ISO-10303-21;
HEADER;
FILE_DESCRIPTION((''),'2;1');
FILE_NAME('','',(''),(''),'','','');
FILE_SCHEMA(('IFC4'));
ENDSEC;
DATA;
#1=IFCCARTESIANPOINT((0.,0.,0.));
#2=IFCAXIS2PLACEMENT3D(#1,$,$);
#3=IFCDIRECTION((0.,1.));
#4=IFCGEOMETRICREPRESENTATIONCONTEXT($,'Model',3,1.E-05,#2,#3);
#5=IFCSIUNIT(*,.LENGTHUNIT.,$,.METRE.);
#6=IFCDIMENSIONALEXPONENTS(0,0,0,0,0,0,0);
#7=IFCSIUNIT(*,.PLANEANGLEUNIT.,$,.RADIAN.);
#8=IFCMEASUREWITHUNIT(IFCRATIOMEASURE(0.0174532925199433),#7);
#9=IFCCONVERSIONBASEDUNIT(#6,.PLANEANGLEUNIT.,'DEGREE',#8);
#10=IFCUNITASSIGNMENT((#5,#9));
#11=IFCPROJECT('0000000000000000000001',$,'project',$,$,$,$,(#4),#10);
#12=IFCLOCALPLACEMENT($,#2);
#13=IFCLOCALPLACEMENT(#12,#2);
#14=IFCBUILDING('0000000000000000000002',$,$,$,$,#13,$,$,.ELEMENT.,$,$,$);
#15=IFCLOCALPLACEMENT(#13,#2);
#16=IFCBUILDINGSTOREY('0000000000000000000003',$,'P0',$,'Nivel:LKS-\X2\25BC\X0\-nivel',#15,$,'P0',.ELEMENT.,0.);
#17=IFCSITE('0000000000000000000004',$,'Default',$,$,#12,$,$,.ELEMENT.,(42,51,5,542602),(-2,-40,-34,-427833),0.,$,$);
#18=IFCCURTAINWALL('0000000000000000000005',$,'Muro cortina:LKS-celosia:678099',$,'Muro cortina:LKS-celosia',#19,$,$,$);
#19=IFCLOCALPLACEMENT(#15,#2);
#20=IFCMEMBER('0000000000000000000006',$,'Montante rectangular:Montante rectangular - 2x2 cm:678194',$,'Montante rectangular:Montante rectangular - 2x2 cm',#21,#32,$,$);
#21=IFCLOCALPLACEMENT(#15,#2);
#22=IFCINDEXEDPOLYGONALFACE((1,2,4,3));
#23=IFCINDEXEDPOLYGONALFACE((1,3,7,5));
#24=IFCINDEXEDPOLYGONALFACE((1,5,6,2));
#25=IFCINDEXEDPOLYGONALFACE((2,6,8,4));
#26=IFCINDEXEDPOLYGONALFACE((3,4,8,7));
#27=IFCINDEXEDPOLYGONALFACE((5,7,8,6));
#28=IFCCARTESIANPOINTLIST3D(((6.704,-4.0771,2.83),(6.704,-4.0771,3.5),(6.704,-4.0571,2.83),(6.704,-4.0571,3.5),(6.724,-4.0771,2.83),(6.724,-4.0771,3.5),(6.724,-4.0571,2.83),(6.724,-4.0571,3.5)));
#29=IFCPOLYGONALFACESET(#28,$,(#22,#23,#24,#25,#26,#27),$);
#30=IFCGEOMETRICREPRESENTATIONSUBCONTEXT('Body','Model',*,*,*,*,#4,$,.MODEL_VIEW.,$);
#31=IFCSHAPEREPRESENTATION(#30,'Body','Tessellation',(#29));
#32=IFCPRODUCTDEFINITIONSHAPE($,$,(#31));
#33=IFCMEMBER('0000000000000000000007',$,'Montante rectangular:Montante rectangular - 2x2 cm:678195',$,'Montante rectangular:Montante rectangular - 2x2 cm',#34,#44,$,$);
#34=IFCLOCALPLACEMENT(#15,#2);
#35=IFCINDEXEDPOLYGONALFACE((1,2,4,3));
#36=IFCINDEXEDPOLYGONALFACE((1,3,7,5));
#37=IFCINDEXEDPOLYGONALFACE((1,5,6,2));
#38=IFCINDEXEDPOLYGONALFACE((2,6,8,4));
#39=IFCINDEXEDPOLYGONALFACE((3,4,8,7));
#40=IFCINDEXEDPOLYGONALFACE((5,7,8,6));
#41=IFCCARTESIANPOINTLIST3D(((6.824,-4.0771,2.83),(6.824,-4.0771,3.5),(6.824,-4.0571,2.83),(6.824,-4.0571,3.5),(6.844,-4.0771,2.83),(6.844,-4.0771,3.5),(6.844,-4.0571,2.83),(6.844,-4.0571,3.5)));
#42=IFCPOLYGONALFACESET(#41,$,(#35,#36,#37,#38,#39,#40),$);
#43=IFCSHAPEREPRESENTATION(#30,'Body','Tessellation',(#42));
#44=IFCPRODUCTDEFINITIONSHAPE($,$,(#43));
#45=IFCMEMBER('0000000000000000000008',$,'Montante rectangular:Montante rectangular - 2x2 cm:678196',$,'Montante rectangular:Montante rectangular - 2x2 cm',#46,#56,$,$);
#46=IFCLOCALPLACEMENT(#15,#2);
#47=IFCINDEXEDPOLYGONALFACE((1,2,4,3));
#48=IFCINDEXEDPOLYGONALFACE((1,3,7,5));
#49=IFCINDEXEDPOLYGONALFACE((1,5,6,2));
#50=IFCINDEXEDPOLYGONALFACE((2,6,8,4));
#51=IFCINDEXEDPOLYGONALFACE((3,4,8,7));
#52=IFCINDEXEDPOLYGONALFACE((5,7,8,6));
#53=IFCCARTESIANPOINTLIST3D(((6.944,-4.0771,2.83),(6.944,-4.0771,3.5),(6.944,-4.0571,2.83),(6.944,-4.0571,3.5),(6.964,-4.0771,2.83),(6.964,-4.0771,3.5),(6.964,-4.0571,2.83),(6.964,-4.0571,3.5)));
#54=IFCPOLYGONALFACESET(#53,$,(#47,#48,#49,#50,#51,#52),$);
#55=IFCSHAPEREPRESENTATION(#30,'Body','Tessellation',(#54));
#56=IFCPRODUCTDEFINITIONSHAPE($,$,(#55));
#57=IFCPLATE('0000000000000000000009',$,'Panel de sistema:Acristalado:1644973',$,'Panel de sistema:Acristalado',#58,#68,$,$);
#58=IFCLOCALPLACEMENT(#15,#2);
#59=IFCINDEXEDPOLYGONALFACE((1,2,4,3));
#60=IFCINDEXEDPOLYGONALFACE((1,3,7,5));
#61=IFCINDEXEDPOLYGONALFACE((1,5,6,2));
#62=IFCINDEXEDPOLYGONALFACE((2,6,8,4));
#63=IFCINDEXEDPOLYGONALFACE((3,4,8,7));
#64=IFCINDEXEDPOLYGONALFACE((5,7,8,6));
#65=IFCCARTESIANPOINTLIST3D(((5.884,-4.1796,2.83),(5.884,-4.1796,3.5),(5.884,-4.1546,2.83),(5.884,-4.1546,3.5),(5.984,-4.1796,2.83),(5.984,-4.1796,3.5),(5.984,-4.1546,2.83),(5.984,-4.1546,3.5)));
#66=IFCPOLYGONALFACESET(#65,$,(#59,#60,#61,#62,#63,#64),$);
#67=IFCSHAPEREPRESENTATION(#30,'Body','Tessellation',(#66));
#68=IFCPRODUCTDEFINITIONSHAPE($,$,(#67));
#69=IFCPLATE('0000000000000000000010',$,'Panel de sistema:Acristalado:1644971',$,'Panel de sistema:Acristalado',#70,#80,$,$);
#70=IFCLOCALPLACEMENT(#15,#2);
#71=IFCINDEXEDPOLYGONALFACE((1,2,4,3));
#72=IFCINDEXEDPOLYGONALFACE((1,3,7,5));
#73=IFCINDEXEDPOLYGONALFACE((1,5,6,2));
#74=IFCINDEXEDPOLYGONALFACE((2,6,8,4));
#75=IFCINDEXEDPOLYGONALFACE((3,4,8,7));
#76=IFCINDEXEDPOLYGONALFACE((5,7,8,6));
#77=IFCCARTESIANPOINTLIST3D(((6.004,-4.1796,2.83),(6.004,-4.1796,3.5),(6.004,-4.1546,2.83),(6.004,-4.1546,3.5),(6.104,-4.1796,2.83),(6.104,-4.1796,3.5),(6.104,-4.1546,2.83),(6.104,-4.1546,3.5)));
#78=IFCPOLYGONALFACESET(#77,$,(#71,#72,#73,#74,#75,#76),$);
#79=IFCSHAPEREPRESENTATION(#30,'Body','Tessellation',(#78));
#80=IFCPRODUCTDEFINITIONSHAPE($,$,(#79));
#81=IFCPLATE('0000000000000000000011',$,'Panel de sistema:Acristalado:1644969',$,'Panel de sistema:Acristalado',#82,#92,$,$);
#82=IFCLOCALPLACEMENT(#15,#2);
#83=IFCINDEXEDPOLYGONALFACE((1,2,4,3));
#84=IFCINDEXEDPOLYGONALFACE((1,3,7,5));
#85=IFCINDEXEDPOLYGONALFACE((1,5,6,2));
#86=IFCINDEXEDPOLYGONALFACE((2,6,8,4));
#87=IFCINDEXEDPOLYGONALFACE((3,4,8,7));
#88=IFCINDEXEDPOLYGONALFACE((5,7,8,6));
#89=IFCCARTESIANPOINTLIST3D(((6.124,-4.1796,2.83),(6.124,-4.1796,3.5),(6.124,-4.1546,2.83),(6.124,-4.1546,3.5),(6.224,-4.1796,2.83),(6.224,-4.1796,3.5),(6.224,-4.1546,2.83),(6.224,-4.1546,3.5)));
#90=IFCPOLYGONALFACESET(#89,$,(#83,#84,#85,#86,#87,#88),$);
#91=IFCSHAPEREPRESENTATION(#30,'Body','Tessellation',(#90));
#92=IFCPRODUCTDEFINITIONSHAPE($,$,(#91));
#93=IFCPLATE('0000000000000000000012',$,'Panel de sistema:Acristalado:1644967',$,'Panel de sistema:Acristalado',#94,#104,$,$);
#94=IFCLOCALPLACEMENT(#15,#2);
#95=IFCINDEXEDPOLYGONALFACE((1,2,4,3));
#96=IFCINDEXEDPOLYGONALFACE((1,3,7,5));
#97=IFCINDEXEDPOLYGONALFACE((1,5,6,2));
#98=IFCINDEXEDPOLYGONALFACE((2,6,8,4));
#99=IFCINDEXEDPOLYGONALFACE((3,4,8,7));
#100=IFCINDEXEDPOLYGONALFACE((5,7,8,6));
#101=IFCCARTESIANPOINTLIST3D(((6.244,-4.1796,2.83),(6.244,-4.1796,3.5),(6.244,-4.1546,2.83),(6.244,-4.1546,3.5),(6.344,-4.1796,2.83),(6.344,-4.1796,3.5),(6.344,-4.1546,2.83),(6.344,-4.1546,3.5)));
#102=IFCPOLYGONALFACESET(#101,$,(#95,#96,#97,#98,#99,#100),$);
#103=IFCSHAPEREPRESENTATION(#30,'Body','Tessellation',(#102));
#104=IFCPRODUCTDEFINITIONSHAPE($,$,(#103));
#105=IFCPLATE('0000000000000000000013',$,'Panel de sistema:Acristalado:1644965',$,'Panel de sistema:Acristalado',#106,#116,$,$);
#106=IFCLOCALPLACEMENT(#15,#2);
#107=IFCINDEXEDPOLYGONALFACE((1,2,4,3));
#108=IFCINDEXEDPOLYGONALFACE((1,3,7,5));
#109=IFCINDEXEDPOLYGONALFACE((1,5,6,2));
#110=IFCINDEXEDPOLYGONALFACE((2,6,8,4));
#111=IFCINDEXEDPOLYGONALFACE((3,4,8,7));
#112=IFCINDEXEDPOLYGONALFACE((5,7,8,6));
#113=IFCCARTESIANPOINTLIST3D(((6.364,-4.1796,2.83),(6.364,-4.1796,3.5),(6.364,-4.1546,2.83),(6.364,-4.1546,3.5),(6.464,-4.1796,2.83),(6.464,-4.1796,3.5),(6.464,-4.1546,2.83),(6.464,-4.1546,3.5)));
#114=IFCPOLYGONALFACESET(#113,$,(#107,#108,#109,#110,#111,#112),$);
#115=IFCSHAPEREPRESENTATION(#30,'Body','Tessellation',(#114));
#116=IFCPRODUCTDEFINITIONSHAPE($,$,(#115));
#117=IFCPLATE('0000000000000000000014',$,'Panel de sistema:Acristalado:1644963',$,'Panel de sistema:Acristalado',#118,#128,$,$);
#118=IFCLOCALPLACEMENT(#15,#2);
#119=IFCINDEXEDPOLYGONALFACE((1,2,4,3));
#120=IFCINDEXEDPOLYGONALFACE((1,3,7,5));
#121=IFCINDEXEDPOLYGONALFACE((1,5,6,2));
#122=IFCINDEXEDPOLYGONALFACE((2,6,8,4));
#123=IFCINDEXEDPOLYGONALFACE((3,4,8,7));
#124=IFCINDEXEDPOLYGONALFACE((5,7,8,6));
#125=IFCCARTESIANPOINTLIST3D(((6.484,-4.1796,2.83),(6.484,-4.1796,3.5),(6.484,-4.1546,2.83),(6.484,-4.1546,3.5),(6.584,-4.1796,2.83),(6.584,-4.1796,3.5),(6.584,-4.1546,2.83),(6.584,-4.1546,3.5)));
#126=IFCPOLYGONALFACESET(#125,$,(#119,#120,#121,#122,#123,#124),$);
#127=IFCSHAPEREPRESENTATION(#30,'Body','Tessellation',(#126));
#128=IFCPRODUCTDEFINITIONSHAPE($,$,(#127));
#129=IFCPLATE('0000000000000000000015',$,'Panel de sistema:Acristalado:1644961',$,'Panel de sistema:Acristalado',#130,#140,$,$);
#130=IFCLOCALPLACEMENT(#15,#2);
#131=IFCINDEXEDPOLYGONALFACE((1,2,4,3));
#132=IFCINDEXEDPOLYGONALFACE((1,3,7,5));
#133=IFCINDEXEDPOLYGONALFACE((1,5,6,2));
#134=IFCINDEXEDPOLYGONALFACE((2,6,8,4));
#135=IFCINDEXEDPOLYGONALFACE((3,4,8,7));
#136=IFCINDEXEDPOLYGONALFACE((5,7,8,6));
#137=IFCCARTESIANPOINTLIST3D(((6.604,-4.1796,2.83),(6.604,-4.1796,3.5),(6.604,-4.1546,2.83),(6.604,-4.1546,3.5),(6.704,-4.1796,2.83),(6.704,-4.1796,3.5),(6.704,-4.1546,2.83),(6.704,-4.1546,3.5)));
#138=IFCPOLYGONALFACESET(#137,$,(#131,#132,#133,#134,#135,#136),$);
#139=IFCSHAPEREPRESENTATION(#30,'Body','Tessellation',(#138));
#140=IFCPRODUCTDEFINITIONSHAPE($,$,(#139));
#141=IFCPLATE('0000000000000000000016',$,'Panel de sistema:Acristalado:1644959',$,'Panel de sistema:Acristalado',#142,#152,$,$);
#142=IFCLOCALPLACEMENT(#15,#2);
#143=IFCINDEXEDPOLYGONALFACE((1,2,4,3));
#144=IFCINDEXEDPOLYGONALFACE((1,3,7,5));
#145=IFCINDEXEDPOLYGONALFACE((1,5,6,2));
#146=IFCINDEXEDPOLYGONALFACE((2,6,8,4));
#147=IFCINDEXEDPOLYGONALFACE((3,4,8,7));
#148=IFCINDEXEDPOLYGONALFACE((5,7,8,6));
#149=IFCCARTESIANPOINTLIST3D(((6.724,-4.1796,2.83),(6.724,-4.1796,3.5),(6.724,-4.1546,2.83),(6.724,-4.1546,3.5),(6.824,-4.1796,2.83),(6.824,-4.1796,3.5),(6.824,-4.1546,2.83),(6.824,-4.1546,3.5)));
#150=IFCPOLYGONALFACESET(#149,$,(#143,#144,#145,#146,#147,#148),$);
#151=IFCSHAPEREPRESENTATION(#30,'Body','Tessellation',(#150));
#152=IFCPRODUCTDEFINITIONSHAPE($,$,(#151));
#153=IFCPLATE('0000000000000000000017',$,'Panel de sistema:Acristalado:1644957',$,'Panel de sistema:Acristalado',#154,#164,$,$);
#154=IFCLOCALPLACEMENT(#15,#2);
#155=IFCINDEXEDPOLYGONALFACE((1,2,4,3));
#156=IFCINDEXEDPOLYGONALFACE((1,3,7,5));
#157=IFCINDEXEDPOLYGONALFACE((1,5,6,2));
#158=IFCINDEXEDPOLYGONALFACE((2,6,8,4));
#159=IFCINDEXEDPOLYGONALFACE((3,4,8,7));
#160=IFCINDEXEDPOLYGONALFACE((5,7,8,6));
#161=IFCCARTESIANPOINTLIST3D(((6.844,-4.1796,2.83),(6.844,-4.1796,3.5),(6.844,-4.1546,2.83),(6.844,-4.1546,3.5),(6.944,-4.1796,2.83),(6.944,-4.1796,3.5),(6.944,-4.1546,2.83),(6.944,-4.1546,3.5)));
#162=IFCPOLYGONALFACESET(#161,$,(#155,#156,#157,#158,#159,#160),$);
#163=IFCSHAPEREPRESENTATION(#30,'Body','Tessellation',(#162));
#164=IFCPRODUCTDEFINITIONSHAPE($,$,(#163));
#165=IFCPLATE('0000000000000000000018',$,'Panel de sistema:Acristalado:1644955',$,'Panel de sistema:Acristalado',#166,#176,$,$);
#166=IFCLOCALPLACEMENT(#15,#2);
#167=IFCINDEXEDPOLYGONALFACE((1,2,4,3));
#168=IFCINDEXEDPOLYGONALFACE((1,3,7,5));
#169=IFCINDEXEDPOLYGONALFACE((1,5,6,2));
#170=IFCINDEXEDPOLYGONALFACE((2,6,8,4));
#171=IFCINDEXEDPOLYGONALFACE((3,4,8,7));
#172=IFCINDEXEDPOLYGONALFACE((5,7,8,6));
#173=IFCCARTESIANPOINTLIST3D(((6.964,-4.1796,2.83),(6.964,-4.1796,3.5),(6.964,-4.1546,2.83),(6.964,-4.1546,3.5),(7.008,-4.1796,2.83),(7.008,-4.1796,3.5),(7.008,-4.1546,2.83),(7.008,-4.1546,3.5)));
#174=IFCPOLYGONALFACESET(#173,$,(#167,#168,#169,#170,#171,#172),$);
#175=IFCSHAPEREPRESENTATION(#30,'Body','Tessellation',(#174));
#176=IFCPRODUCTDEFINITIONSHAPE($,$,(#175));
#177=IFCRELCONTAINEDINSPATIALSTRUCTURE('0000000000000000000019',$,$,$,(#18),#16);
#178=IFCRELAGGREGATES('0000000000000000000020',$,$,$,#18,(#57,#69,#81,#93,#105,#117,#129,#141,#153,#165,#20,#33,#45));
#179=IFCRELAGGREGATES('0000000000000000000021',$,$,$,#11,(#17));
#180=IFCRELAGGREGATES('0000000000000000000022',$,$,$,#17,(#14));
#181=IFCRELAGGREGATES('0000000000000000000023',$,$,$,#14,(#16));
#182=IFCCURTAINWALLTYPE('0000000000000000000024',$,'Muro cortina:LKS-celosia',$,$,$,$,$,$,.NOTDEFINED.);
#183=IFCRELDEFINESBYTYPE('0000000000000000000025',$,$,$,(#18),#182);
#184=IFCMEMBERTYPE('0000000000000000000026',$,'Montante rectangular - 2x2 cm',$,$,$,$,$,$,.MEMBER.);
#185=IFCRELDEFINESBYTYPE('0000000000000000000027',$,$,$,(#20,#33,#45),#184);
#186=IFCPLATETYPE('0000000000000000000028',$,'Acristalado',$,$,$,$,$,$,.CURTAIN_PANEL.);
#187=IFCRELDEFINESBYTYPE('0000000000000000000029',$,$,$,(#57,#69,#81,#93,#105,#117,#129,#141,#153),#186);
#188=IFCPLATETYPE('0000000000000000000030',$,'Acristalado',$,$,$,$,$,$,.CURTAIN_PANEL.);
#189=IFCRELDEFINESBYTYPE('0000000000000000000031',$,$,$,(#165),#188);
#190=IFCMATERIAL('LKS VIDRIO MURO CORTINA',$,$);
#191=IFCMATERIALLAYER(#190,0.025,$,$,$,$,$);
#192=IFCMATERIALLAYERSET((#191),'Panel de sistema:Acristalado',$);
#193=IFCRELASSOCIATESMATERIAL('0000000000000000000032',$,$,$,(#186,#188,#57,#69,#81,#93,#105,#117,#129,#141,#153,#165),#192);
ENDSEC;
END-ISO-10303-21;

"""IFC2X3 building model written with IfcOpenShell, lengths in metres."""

from ifc_helpers import new_model, entity, si_unit, converted_unit, direction, frame, origin, origin_2d_with_axis, place, context, subcontext, project, spatial, rectangle, extrude, source, transform, mapped, material, layer, layer_set, layer_usage, type_object, type_shapes, element, aggregate, save


model = new_model("IFC2X3")

# Units and contexts
model_context = context("Model", 3, precision=1e-05, world=origin(), true_north=direction((0.0, 1.0)))
body_context = subcontext(model_context, "Body", "Model", "MODEL_VIEW")
ifc_project = project(units=[si_unit("LENGTHUNIT", "METRE"), converted_unit("PLANEANGLEUNIT", "DEGREE", entity("IfcRatioMeasure", 0.0174532925199433), si_unit("PLANEANGLEUNIT", "RADIAN"), dimensions=[0, 0, 0, 0, 0, 0, 0])], contexts=[model_context])

# Site, building, storey
site_placement = place(None, origin())
site = spatial("IfcSite", under=ifc_project, at=site_placement, Name="Default", CompositionType="ELEMENT", RefLatitude=(42, 51, 5, 542602), RefLongitude=(-2, -40, -34, -427833), RefElevation=0.0)
building_placement = place(site_placement, origin())
building = spatial("IfcBuilding", under=site, at=building_placement, CompositionType="ELEMENT")
storey_placement = place(building_placement, origin())
storey = spatial("IfcBuildingStorey", under=building, at=storey_placement, Name="P0", ObjectType="Nivel:LKS-▼-nivel", LongName="P0", CompositionType="ELEMENT", Elevation=0.0)

# Curtain wall
curtain_wall_type = type_object("IfcCurtainWallType", Name="Muro cortina:LKS-celosia", PredefinedType="NOTDEFINED")
curtain_wall_1_placement = place(storey_placement, origin())
curtain_wall_1 = element("IfcCurtainWall", 1, at=curtain_wall_1_placement, inside=storey, type_object=curtain_wall_type, Name="Muro cortina:LKS-celosia:678099", ObjectType="Muro cortina:LKS-celosia")

# Shared definitions
member_type_1 = type_object("IfcMemberType", Name="Montante rectangular - 2x2 cm", PredefinedType="MEMBER")
shared_shape_1 = source(origin(), body_context, "Body", "SweptSolid", [
    extrude(rectangle(XDim=0.02, YDim=0.02, at=origin_2d_with_axis()), frame((0.0, -0.1, -0.67), z_axis=(0.0, 0.0, 1.0), x_axis=(0.0, -1.0, 0.0)), (0.0, 0.0, 1.0), 0.67),
])
type_shapes(member_type_1, [shared_shape_1])

# Members
member_1_placement = place(storey_placement, frame((6.714, -4.1671, 2.83), z_axis=(0.0, 0.0, -1.0), x_axis=(1.0, 0.0, 0.0)))
member_1 = element("IfcMember", 2, at=member_1_placement, type_object=member_type_1, Name="Montante rectangular:Montante rectangular - 2x2 cm:678194", ObjectType="Montante rectangular:Montante rectangular - 2x2 cm", context=body_context, shape_type="MappedRepresentation", body=[
    mapped(shared_shape_1, transform((0.0, 0.0, 0.0), scale=1.0)),
])
member_2_placement = place(storey_placement, frame((6.834, -4.1671, 2.83), z_axis=(0.0, 0.0, -1.0), x_axis=(1.0, 0.0, 0.0)))
member_2 = element("IfcMember", 3, at=member_2_placement, type_object=member_type_1, Name="Montante rectangular:Montante rectangular - 2x2 cm:678195", ObjectType="Montante rectangular:Montante rectangular - 2x2 cm", context=body_context, shape_type="MappedRepresentation", body=[
    mapped(shared_shape_1, transform((0.0, 0.0, 0.0), scale=1.0)),
])
member_3_placement = place(storey_placement, frame((6.954, -4.1671, 2.83), z_axis=(0.0, 0.0, -1.0), x_axis=(1.0, 0.0, 0.0)))
member_3 = element("IfcMember", 4, at=member_3_placement, type_object=member_type_1, Name="Montante rectangular:Montante rectangular - 2x2 cm:678196", ObjectType="Montante rectangular:Montante rectangular - 2x2 cm", context=body_context, shape_type="MappedRepresentation", body=[
    mapped(shared_shape_1, transform((0.0, 0.0, 0.0), scale=1.0)),
])

# Plates
ifc_material = material(Name="LKS VIDRIO MURO CORTINA")
ifc_layer = layer(ifc_material, 0.025)
ifc_layer_set = layer_set([ifc_layer], Name="Panel de sistema:Acristalado")
ifc_layer_usage_1 = layer_usage(ifc_layer_set, "AXIS3", "POSITIVE", 0.0)
plate_type_1 = type_object("IfcPlateType", Name="Acristalado", PredefinedType="CURTAIN_PANEL", material=ifc_layer_set)
shared_shape_2 = source(origin(), body_context, "Body", "SweptSolid", [
    extrude(rectangle(XDim=0.025, YDim=0.1, at=origin_2d_with_axis()), frame((0.0, 0.0, 0.0), z_axis=(0.0, 0.0, 1.0), x_axis=(0.0, 1.0, 0.0)), (0.0, 0.0, 1.0), 0.67),
])
type_shapes(plate_type_1, [shared_shape_2])
plate_1_placement = place(curtain_wall_1_placement, frame((5.934, -4.1671, 2.83)))
plate_1 = element("IfcPlate", 5, at=plate_1_placement, type_object=plate_type_1, material=ifc_layer_usage_1, Name="Panel de sistema:Acristalado:1644973", ObjectType="Panel de sistema:Acristalado", context=body_context, shape_type="MappedRepresentation", body=[
    mapped(shared_shape_2, transform((0.0, 0.0, 0.0), scale=1.0)),
])
ifc_layer_usage_2 = layer_usage(ifc_layer_set, "AXIS3", "POSITIVE", 0.0)
plate_2_placement = place(curtain_wall_1_placement, frame((6.054, -4.1671, 2.83)))
plate_2 = element("IfcPlate", 6, at=plate_2_placement, type_object=plate_type_1, material=ifc_layer_usage_2, Name="Panel de sistema:Acristalado:1644971", ObjectType="Panel de sistema:Acristalado", context=body_context, shape_type="MappedRepresentation", body=[
    mapped(shared_shape_2, transform((0.0, 0.0, 0.0), scale=1.0)),
])
ifc_layer_usage_3 = layer_usage(ifc_layer_set, "AXIS3", "POSITIVE", 0.0)
plate_3_placement = place(curtain_wall_1_placement, frame((6.174, -4.1671, 2.83)))
plate_3 = element("IfcPlate", 7, at=plate_3_placement, type_object=plate_type_1, material=ifc_layer_usage_3, Name="Panel de sistema:Acristalado:1644969", ObjectType="Panel de sistema:Acristalado", context=body_context, shape_type="MappedRepresentation", body=[
    mapped(shared_shape_2, transform((0.0, 0.0, 0.0), scale=1.0)),
])
ifc_layer_usage_4 = layer_usage(ifc_layer_set, "AXIS3", "POSITIVE", 0.0)
plate_4_placement = place(curtain_wall_1_placement, frame((6.294, -4.1671, 2.83)))
plate_4 = element("IfcPlate", 8, at=plate_4_placement, type_object=plate_type_1, material=ifc_layer_usage_4, Name="Panel de sistema:Acristalado:1644967", ObjectType="Panel de sistema:Acristalado", context=body_context, shape_type="MappedRepresentation", body=[
    mapped(shared_shape_2, transform((0.0, 0.0, 0.0), scale=1.0)),
])
ifc_layer_usage_5 = layer_usage(ifc_layer_set, "AXIS3", "POSITIVE", 0.0)
plate_5_placement = place(curtain_wall_1_placement, frame((6.414, -4.1671, 2.83)))
plate_5 = element("IfcPlate", 9, at=plate_5_placement, type_object=plate_type_1, material=ifc_layer_usage_5, Name="Panel de sistema:Acristalado:1644965", ObjectType="Panel de sistema:Acristalado", context=body_context, shape_type="MappedRepresentation", body=[
    mapped(shared_shape_2, transform((0.0, 0.0, 0.0), scale=1.0)),
])
ifc_layer_usage_6 = layer_usage(ifc_layer_set, "AXIS3", "POSITIVE", 0.0)
plate_6_placement = place(curtain_wall_1_placement, frame((6.534, -4.1671, 2.83)))
plate_6 = element("IfcPlate", 10, at=plate_6_placement, type_object=plate_type_1, material=ifc_layer_usage_6, Name="Panel de sistema:Acristalado:1644963", ObjectType="Panel de sistema:Acristalado", context=body_context, shape_type="MappedRepresentation", body=[
    mapped(shared_shape_2, transform((0.0, 0.0, 0.0), scale=1.0)),
])
ifc_layer_usage_7 = layer_usage(ifc_layer_set, "AXIS3", "POSITIVE", 0.0)
plate_7_placement = place(curtain_wall_1_placement, frame((6.654, -4.1671, 2.83)))
plate_7 = element("IfcPlate", 11, at=plate_7_placement, type_object=plate_type_1, material=ifc_layer_usage_7, Name="Panel de sistema:Acristalado:1644961", ObjectType="Panel de sistema:Acristalado", context=body_context, shape_type="MappedRepresentation", body=[
    mapped(shared_shape_2, transform((0.0, 0.0, 0.0), scale=1.0)),
])
ifc_layer_usage_8 = layer_usage(ifc_layer_set, "AXIS3", "POSITIVE", 0.0)
plate_8_placement = place(curtain_wall_1_placement, frame((6.774, -4.1671, 2.83)))
plate_8 = element("IfcPlate", 12, at=plate_8_placement, type_object=plate_type_1, material=ifc_layer_usage_8, Name="Panel de sistema:Acristalado:1644959", ObjectType="Panel de sistema:Acristalado", context=body_context, shape_type="MappedRepresentation", body=[
    mapped(shared_shape_2, transform((0.0, 0.0, 0.0), scale=1.0)),
])
ifc_layer_usage_9 = layer_usage(ifc_layer_set, "AXIS3", "POSITIVE", 0.0)
plate_9_placement = place(curtain_wall_1_placement, frame((6.894, -4.1671, 2.83)))
plate_9 = element("IfcPlate", 13, at=plate_9_placement, type_object=plate_type_1, material=ifc_layer_usage_9, Name="Panel de sistema:Acristalado:1644957", ObjectType="Panel de sistema:Acristalado", context=body_context, shape_type="MappedRepresentation", body=[
    mapped(shared_shape_2, transform((0.0, 0.0, 0.0), scale=1.0)),
])
ifc_layer_usage_10 = layer_usage(ifc_layer_set, "AXIS3", "POSITIVE", 0.0)
plate_type_2 = type_object("IfcPlateType", Name="Acristalado", PredefinedType="CURTAIN_PANEL", material=ifc_layer_set)
shared_shape_3 = source(origin(), body_context, "Body", "SweptSolid", [
    extrude(rectangle(XDim=0.025, YDim=0.044, at=origin_2d_with_axis()), frame((0.0, 0.0, 0.0), z_axis=(0.0, 0.0, 1.0), x_axis=(0.0, 1.0, 0.0)), (0.0, 0.0, 1.0), 0.67),
])
type_shapes(plate_type_2, [shared_shape_3])
plate_10_placement = place(curtain_wall_1_placement, frame((6.986, -4.1671, 2.83)))
plate_10 = element("IfcPlate", 14, at=plate_10_placement, type_object=plate_type_2, material=ifc_layer_usage_10, Name="Panel de sistema:Acristalado:1644955", ObjectType="Panel de sistema:Acristalado", context=body_context, shape_type="MappedRepresentation", body=[
    mapped(shared_shape_3, transform((0.0, 0.0, 0.0), scale=1.0)),
])
aggregate(curtain_wall_1, [plate_1, plate_2, plate_3, plate_4, plate_5, plate_6, plate_7, plate_8, plate_9, plate_10, member_1, member_2, member_3])

save(model, "model.ifc")
